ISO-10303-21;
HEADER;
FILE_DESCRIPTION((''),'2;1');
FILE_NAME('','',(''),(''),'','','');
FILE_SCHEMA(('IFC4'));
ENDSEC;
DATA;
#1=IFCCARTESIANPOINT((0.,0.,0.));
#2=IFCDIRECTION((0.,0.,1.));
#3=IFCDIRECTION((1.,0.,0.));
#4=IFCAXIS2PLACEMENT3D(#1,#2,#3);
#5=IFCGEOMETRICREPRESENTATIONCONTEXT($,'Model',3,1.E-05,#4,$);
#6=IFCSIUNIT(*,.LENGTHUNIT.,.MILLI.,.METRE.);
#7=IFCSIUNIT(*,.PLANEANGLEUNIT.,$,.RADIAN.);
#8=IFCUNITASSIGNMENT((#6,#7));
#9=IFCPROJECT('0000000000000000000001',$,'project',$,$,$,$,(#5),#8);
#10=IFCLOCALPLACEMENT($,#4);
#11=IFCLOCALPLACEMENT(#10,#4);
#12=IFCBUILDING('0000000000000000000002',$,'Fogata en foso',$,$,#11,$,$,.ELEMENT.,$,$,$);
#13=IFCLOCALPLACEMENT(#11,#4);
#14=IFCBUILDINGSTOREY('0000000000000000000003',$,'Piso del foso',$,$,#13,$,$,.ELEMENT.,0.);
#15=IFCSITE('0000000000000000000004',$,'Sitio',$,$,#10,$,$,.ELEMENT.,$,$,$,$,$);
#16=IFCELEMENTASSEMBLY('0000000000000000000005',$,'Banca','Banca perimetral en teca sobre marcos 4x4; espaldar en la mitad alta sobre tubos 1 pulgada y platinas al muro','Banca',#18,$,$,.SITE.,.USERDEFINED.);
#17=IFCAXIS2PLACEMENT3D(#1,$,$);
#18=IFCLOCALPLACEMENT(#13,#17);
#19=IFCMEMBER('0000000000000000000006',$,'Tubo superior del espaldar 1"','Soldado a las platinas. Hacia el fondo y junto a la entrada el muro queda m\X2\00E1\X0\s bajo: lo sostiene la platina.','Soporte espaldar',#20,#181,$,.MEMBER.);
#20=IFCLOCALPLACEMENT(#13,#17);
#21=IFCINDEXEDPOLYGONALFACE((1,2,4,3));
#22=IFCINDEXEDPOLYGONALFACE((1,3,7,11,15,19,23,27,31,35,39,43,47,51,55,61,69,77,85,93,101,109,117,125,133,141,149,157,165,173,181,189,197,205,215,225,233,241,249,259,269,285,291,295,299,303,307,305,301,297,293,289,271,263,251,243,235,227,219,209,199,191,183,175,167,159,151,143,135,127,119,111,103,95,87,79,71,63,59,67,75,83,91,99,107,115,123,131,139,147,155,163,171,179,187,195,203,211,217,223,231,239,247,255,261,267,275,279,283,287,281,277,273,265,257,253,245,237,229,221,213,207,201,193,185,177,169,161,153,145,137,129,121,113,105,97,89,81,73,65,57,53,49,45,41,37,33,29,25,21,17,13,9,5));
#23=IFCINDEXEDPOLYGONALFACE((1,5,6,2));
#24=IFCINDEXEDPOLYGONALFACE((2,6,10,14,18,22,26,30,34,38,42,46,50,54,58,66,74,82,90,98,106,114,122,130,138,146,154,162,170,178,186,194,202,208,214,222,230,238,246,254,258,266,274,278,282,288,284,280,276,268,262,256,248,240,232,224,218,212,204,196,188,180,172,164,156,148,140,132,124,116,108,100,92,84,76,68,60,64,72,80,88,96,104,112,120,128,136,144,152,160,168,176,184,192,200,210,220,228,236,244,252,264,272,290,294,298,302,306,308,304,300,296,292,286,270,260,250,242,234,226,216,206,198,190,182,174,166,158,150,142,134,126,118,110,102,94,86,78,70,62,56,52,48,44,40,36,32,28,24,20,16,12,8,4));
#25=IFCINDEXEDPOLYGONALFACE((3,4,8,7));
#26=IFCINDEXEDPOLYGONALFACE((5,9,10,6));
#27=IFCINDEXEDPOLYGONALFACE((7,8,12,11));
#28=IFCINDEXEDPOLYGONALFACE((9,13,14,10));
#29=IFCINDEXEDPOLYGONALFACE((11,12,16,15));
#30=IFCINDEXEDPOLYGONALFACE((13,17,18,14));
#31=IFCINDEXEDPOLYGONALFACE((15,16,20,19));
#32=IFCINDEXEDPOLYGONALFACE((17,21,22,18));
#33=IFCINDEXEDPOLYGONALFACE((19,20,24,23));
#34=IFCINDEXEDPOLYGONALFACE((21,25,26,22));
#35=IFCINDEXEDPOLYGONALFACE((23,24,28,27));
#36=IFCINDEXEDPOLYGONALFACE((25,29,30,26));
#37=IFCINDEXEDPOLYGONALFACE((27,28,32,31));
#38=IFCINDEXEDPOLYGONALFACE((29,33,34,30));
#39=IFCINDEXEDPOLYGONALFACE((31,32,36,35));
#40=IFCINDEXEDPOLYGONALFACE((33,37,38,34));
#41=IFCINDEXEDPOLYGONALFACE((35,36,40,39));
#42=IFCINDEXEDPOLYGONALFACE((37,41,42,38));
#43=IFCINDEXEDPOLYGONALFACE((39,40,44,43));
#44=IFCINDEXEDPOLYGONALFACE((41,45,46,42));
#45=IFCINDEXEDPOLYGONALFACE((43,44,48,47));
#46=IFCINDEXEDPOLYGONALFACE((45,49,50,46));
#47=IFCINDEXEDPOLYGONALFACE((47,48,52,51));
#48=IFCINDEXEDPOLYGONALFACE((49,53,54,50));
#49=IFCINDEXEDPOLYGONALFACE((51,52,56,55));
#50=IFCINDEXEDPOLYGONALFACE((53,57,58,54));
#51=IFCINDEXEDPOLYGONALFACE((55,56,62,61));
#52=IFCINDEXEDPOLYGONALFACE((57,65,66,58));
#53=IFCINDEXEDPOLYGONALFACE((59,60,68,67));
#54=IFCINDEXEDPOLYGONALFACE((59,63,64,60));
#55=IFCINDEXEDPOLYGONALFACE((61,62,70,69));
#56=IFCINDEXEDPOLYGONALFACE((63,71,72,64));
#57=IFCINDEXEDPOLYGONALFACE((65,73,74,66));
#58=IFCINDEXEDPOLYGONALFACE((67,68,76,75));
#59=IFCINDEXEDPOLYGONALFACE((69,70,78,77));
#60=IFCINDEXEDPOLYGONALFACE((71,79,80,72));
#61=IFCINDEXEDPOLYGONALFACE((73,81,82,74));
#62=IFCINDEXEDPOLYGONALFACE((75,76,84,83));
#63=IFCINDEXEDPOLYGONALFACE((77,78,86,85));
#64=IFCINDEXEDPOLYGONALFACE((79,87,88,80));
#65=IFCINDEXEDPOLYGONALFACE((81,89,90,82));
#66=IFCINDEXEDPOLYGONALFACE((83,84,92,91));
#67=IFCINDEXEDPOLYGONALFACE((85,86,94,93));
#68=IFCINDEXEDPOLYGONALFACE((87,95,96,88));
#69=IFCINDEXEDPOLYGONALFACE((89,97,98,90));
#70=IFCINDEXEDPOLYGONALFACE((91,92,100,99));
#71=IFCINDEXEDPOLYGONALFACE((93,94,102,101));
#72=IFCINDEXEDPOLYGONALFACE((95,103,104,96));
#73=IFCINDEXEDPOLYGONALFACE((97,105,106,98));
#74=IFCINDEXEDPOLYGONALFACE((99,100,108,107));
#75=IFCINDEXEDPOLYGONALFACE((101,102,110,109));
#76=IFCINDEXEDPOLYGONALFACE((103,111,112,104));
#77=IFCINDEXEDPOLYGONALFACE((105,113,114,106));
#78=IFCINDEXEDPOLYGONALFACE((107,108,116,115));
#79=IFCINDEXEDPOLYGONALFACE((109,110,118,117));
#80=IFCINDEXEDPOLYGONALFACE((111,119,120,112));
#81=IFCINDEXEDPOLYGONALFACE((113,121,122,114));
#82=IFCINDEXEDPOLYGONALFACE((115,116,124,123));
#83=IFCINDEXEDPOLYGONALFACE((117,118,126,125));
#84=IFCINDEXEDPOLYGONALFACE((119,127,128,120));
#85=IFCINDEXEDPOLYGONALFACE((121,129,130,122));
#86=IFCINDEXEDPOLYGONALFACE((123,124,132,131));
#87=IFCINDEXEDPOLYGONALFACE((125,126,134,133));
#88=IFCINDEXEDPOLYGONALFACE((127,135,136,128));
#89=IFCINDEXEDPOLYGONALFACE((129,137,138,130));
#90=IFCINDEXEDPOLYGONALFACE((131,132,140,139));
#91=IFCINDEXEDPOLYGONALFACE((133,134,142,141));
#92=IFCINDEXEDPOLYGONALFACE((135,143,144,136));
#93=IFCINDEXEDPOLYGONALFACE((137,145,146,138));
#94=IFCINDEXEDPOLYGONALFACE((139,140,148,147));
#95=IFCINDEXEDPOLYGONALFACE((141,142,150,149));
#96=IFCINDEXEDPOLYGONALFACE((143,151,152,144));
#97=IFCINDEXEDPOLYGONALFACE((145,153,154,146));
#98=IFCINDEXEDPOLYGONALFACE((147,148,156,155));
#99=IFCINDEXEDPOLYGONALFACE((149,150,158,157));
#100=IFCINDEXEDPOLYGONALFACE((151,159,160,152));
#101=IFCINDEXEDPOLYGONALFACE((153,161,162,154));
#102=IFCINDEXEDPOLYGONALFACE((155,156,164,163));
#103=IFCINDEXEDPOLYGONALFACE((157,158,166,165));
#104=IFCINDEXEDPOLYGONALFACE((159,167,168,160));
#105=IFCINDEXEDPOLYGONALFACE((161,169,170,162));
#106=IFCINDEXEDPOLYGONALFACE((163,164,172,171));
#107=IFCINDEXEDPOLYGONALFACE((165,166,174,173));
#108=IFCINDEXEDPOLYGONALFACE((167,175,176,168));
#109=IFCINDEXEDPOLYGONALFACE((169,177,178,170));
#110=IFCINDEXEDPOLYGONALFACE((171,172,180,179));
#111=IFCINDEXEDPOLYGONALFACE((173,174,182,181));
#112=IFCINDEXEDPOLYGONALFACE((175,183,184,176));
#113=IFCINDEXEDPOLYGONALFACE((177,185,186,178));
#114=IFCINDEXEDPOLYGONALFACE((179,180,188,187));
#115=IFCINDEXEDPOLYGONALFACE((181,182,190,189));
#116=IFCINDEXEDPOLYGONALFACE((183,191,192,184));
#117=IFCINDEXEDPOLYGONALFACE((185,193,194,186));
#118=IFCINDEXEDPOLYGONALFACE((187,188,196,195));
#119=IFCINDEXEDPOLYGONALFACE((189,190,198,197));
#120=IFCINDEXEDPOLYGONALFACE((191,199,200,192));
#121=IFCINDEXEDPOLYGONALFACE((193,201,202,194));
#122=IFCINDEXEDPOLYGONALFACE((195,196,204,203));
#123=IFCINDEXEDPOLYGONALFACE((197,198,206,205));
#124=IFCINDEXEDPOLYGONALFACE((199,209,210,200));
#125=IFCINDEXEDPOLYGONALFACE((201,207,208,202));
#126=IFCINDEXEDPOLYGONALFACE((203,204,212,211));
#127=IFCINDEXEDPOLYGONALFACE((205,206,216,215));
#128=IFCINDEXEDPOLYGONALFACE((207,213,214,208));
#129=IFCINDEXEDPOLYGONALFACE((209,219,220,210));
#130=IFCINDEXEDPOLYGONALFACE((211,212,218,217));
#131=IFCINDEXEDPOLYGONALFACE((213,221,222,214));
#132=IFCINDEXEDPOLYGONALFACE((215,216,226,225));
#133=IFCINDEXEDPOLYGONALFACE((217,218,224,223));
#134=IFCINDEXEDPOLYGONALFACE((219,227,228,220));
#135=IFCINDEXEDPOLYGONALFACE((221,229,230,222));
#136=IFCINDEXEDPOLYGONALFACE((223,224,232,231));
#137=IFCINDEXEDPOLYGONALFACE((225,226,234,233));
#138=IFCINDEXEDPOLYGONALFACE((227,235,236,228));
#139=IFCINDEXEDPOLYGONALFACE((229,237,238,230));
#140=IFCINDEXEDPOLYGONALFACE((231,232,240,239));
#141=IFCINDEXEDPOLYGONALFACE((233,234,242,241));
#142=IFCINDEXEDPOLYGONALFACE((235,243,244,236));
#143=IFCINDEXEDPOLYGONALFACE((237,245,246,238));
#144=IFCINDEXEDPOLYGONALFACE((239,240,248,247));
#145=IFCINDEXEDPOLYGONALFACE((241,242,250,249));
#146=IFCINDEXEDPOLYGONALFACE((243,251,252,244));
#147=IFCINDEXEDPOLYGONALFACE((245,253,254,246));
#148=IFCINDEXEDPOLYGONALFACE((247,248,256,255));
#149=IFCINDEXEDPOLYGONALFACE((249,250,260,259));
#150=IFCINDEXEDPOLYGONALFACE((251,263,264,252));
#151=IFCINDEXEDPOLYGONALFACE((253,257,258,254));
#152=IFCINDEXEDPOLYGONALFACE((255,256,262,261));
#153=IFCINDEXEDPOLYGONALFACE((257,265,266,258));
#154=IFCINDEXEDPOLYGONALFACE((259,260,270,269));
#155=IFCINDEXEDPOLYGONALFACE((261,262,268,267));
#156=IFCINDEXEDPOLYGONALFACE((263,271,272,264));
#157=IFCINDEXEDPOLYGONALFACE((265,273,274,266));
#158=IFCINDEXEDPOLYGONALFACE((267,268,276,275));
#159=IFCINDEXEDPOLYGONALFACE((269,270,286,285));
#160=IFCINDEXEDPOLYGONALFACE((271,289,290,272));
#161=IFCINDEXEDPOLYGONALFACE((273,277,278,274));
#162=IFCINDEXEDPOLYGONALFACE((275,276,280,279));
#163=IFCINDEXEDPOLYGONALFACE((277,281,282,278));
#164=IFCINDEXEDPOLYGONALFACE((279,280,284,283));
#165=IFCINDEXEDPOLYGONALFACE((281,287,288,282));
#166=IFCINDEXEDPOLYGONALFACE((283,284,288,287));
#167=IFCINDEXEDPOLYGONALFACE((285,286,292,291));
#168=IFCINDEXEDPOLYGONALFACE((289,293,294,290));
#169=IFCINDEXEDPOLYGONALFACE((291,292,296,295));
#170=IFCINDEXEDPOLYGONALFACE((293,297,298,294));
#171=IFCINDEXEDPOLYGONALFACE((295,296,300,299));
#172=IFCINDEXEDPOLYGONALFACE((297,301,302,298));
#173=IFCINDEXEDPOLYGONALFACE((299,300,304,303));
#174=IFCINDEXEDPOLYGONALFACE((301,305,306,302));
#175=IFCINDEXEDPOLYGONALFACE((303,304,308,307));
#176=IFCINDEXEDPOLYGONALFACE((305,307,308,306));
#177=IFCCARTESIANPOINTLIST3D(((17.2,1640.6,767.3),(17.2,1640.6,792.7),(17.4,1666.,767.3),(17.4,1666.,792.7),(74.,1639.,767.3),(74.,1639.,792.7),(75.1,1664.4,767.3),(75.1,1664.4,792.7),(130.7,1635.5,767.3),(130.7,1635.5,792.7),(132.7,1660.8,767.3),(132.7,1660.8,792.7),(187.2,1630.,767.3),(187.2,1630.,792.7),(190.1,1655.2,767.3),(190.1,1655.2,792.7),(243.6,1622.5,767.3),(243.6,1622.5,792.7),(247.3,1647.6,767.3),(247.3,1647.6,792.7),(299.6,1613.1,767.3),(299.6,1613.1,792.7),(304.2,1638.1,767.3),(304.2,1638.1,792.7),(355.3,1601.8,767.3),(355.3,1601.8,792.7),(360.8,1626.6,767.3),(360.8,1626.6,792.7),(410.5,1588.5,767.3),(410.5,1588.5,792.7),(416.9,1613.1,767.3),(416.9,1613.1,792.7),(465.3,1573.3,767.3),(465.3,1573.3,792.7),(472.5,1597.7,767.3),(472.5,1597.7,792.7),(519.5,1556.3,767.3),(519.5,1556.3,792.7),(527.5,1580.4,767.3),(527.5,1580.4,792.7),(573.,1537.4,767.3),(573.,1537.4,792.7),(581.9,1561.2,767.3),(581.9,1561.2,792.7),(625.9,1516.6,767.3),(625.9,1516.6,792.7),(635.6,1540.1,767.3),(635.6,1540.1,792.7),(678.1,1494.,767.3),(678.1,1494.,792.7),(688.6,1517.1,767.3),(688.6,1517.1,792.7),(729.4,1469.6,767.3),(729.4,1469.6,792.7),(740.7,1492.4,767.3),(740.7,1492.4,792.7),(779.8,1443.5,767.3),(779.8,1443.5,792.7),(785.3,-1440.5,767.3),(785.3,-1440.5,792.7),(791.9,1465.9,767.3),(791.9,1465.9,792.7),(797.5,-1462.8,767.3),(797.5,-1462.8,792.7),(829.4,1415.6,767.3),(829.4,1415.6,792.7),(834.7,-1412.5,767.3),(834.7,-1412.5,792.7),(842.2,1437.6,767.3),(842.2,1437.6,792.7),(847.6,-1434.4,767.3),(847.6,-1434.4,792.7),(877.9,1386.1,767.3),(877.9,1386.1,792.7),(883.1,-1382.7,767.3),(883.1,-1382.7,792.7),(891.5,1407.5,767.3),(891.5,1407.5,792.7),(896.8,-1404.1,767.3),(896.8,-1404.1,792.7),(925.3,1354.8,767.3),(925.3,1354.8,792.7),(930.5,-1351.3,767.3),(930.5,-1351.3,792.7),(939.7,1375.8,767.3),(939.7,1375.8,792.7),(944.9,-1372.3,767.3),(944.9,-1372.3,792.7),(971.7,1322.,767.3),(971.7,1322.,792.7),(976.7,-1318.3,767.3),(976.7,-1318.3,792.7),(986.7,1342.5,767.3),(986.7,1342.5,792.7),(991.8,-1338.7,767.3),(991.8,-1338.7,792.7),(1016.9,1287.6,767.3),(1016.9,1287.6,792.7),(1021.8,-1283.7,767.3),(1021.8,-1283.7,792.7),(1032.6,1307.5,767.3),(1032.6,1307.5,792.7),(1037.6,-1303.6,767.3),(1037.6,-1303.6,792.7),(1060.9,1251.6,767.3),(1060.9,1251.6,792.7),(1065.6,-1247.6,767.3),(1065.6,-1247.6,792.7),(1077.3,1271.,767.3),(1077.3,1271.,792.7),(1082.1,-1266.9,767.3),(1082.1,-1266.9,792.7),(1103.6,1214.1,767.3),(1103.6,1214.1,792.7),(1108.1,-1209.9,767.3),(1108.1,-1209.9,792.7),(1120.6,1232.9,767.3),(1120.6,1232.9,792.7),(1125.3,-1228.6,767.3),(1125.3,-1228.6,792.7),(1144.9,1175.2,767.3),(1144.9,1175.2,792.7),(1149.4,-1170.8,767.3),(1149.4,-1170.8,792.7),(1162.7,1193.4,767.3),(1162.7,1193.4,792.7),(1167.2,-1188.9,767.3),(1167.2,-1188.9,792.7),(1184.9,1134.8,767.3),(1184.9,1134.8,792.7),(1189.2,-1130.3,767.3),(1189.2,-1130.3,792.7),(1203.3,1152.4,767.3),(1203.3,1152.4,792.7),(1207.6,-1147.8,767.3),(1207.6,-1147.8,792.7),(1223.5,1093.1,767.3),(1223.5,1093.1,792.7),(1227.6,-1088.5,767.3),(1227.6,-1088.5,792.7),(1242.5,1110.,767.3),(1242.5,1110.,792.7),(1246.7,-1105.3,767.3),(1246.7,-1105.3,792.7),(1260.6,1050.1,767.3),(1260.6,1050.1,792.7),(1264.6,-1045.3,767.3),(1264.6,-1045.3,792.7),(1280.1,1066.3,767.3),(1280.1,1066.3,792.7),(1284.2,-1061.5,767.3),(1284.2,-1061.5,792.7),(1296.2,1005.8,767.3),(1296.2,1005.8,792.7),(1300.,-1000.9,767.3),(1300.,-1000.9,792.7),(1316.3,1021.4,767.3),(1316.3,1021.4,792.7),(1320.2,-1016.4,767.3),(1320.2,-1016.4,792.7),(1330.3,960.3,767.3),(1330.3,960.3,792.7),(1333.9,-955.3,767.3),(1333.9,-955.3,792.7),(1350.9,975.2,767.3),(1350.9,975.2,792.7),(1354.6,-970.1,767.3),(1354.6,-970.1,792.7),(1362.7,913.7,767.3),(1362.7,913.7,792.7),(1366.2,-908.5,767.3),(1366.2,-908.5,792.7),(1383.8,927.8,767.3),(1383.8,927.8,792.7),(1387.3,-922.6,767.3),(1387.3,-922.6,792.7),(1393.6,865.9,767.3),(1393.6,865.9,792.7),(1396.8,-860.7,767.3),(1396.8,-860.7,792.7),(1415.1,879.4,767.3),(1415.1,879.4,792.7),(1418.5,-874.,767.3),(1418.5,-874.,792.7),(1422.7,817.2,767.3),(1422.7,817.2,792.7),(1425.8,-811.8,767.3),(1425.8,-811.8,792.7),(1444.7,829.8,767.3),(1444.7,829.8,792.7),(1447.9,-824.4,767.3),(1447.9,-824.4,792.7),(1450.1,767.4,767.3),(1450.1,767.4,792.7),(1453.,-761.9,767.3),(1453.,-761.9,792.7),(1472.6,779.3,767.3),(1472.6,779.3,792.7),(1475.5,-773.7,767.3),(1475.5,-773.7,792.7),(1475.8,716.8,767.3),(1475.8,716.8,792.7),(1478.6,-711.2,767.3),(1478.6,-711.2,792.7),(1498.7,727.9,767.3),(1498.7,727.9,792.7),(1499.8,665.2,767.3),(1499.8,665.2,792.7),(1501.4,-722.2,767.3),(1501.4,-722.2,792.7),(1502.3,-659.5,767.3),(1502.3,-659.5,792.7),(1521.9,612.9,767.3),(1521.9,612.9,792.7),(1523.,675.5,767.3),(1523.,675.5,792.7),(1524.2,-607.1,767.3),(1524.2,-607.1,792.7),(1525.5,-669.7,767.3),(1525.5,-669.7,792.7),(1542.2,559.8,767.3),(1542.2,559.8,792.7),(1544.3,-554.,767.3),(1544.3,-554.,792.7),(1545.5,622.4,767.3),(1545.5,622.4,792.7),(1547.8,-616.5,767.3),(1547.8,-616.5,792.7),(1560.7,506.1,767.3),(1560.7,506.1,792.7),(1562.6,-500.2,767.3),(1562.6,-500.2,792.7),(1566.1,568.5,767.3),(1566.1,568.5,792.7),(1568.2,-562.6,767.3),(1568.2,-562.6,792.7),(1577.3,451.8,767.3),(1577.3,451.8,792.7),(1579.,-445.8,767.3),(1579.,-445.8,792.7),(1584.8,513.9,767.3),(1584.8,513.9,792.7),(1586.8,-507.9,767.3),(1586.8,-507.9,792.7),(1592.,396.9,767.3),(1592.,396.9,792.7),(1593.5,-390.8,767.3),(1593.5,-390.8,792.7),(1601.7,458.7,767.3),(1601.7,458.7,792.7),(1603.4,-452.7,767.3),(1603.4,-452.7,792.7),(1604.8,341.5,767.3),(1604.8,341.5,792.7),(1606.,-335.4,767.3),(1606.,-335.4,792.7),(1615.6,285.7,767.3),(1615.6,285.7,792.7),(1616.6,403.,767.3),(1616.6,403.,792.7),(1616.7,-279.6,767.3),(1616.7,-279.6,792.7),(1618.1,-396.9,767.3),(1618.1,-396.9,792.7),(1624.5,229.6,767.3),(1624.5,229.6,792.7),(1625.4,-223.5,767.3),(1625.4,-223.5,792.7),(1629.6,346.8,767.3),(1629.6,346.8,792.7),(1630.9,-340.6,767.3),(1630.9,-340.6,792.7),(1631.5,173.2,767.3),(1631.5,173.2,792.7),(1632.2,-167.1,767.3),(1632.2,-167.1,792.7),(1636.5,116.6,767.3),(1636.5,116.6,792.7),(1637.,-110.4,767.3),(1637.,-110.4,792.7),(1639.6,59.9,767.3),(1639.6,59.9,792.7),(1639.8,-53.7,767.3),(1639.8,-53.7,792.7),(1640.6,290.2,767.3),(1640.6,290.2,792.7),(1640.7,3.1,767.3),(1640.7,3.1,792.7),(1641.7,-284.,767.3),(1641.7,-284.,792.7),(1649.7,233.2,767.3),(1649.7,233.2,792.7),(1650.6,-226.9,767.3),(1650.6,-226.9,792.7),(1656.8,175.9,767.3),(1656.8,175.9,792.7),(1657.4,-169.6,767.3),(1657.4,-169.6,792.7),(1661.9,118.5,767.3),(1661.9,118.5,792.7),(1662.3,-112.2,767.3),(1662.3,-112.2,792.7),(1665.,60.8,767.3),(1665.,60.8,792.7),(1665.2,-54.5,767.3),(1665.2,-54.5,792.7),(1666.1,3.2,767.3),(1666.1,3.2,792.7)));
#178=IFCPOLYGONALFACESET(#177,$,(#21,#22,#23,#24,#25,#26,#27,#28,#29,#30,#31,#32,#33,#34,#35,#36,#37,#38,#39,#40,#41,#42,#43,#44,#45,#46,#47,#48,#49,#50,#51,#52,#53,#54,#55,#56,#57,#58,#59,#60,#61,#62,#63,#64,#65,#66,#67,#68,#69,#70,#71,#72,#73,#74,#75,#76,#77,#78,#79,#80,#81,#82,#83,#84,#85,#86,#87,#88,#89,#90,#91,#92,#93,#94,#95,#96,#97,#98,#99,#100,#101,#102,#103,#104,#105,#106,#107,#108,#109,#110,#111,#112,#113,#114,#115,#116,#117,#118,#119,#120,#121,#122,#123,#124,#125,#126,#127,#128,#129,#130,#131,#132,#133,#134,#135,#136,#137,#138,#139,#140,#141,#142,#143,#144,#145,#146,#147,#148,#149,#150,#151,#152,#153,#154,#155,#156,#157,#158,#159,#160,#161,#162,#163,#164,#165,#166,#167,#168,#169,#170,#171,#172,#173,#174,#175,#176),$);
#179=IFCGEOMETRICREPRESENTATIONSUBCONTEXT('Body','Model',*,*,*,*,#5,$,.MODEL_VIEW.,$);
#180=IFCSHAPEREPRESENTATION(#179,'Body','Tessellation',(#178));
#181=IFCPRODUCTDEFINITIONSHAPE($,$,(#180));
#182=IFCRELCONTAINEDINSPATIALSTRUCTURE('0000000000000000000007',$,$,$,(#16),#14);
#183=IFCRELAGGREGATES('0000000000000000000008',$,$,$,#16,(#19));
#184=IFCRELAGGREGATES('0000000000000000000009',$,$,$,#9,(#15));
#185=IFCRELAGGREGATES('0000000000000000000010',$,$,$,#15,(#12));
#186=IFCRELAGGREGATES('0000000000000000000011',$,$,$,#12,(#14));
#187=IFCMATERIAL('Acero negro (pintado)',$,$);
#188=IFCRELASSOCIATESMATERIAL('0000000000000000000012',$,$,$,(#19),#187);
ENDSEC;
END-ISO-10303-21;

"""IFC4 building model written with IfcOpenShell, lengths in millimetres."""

from ifc_helpers import new_model, si_unit, frame, origin_with_axes, place, context, subcontext, project, spatial, polyline, outline, extrude, material, element, aggregate, save


model = new_model("IFC4")

# Units and contexts
model_context = context("Model", 3, precision=1e-05, world=origin_with_axes())
body_context = subcontext(model_context, "Body", "Model", "MODEL_VIEW")
ifc_project = project(units=[si_unit("LENGTHUNIT", "METRE", prefix="MILLI"), si_unit("PLANEANGLEUNIT", "RADIAN")], contexts=[model_context])

# Site, building, storey
site_placement = place(None, origin_with_axes())
site = spatial("IfcSite", under=ifc_project, at=site_placement, Name="Sitio", CompositionType="ELEMENT")
building_placement = place(site_placement, origin_with_axes())
building = spatial("IfcBuilding", under=site, at=building_placement, Name="Fogata en foso", CompositionType="ELEMENT")
storey_placement = place(building_placement, origin_with_axes())
storey = spatial("IfcBuildingStorey", under=building, at=storey_placement, Name="Piso del foso", CompositionType="ELEMENT", Elevation=0.0)

# Element assembly, member
assembly_1_placement = place(storey_placement, origin_with_axes())
assembly_1 = element("IfcElementAssembly", 1, at=assembly_1_placement, inside=storey, Name="Banca", Description="Banca perimetral en teca sobre marcos 4x4; espaldar en la mitad alta sobre tubos 1 pulgada y platinas al muro", ObjectType="Banca", AssemblyPlace="SITE", PredefinedType="USERDEFINED")
ifc_material_1 = material(Name="Acero negro (pintado)")
member_1_placement = place(storey_placement, frame((0.0, 0.0, 767.3), z_axis=(0.0, 0.0, 1.0), x_axis=(1.0, 0.0, 0.0)))
member_1 = element("IfcMember", 2, at=member_1_placement, material=ifc_material_1, Name="Tubo superior del espaldar 1\"", Description="Soldado a las platinas. Hacia el fondo y junto a la entrada el muro queda más bajo: lo sostiene la platina.", ObjectType="Soporte espaldar", PredefinedType="MEMBER", context=body_context, shape_type="SweptSolid", body=[
    extrude(outline(polyline([(797.5, -1462.8), (847.6, -1434.4), (896.8, -1404.1), (944.9, -1372.3), (991.8, -1338.7), (1037.6, -1303.6), (1082.1, -1266.9), (1125.3, -1228.6), (1167.2, -1188.9), (1207.6, -1147.8), (1246.7, -1105.3), (1284.2, -1061.5), (1320.2, -1016.4), (1354.6, -970.1), (1387.3, -922.6), (1418.5, -874.0), (1447.9, -824.4), (1475.5, -773.7), (1501.4, -722.2), (1525.5, -669.7), (1547.8, -616.5), (1568.2, -562.6), (1586.8, -507.9), (1603.4, -452.7), (1618.1, -396.9), (1630.9, -340.6), (1641.7, -283.9), (1650.6, -226.9), (1657.4, -169.6), (1662.3, -112.2), (1665.2, -54.5), (1666.1, 3.2), (1665.0, 60.8), (1661.9, 118.5), (1656.8, 175.9), (1649.7, 233.2), (1640.6, 290.2), (1629.6, 346.8), (1616.6, 403.0), (1601.7, 458.7), (1584.8, 513.9), (1566.1, 568.5), (1545.5, 622.4), (1523.0, 675.5), (1498.7, 727.9), (1472.6, 779.3), (1444.7, 829.8), (1415.1, 879.4), (1383.8, 927.8), (1350.9, 975.2), (1316.3, 1021.4), (1280.1, 1066.3), (1242.5, 1110.0), (1203.3, 1152.4), (1162.7, 1193.4), (1120.6, 1232.9), (1077.3, 1271.0), (1032.6, 1307.5), (986.7, 1342.5), (939.7, 1375.8), (891.5, 1407.5), (842.2, 1437.6), (791.9, 1465.9), (740.7, 1492.4), (688.6, 1517.1), (635.6, 1540.1), (581.9, 1561.2), (527.5, 1580.4), (472.5, 1597.7), (416.9, 1613.1), (360.8, 1626.6), (304.2, 1638.1), (247.3, 1647.6), (190.1, 1655.2), (132.7, 1660.8), (75.1, 1664.4), (17.4, 1666.0), (17.2, 1640.6), (74.0, 1639.0), (130.7, 1635.5), (187.2, 1630.0), (243.6, 1622.5), (299.6, 1613.1), (355.3, 1601.8), (410.5, 1588.5), (465.3, 1573.3), (519.5, 1556.3), (573.0, 1537.4), (625.9, 1516.6), (678.1, 1494.0), (729.4, 1469.6), (779.8, 1443.5), (829.4, 1415.6), (877.9, 1386.1), (925.3, 1354.8), (971.7, 1322.0), (1016.9, 1287.6), (1060.9, 1251.6), (1103.6, 1214.1), (1144.9, 1175.2), (1184.9, 1134.8), (1223.5, 1093.1), (1260.6, 1050.1), (1296.2, 1005.8), (1330.3, 960.3), (1362.7, 913.7), (1393.6, 865.9), (1422.7, 817.2), (1450.1, 767.4), (1475.8, 716.8), (1499.8, 665.2), (1521.9, 612.9), (1542.2, 559.8), (1560.7, 506.1), (1577.3, 451.8), (1592.0, 396.9), (1604.8, 341.5), (1615.6, 285.7), (1624.5, 229.6), (1631.5, 173.2), (1636.5, 116.6), (1639.6, 59.9), (1640.7, 3.1), (1639.8, -53.7), (1637.0, -110.4), (1632.2, -167.1), (1625.4, -223.5), (1616.7, -279.6), (1606.0, -335.4), (1593.5, -390.8), (1579.0, -445.8), (1562.6, -500.2), (1544.3, -554.0), (1524.2, -607.1), (1502.3, -659.5), (1478.6, -711.2), (1453.0, -761.9), (1425.8, -811.8), (1396.8, -860.7), (1366.2, -908.5), (1333.9, -955.3), (1300.0, -1000.9), (1264.6, -1045.3), (1227.7, -1088.5), (1189.2, -1130.3), (1149.4, -1170.8), (1108.1, -1209.9), (1065.6, -1247.6), (1021.8, -1283.7), (976.7, -1318.3), (930.5, -1351.3), (883.1, -1382.7), (834.7, -1412.5), (785.3, -1440.5), (797.5, -1462.8)])), origin_with_axes(), (0.0, 0.0, 1.0), 25.4),
])
aggregate(assembly_1, [member_1])

save(model, "model.ifc")
